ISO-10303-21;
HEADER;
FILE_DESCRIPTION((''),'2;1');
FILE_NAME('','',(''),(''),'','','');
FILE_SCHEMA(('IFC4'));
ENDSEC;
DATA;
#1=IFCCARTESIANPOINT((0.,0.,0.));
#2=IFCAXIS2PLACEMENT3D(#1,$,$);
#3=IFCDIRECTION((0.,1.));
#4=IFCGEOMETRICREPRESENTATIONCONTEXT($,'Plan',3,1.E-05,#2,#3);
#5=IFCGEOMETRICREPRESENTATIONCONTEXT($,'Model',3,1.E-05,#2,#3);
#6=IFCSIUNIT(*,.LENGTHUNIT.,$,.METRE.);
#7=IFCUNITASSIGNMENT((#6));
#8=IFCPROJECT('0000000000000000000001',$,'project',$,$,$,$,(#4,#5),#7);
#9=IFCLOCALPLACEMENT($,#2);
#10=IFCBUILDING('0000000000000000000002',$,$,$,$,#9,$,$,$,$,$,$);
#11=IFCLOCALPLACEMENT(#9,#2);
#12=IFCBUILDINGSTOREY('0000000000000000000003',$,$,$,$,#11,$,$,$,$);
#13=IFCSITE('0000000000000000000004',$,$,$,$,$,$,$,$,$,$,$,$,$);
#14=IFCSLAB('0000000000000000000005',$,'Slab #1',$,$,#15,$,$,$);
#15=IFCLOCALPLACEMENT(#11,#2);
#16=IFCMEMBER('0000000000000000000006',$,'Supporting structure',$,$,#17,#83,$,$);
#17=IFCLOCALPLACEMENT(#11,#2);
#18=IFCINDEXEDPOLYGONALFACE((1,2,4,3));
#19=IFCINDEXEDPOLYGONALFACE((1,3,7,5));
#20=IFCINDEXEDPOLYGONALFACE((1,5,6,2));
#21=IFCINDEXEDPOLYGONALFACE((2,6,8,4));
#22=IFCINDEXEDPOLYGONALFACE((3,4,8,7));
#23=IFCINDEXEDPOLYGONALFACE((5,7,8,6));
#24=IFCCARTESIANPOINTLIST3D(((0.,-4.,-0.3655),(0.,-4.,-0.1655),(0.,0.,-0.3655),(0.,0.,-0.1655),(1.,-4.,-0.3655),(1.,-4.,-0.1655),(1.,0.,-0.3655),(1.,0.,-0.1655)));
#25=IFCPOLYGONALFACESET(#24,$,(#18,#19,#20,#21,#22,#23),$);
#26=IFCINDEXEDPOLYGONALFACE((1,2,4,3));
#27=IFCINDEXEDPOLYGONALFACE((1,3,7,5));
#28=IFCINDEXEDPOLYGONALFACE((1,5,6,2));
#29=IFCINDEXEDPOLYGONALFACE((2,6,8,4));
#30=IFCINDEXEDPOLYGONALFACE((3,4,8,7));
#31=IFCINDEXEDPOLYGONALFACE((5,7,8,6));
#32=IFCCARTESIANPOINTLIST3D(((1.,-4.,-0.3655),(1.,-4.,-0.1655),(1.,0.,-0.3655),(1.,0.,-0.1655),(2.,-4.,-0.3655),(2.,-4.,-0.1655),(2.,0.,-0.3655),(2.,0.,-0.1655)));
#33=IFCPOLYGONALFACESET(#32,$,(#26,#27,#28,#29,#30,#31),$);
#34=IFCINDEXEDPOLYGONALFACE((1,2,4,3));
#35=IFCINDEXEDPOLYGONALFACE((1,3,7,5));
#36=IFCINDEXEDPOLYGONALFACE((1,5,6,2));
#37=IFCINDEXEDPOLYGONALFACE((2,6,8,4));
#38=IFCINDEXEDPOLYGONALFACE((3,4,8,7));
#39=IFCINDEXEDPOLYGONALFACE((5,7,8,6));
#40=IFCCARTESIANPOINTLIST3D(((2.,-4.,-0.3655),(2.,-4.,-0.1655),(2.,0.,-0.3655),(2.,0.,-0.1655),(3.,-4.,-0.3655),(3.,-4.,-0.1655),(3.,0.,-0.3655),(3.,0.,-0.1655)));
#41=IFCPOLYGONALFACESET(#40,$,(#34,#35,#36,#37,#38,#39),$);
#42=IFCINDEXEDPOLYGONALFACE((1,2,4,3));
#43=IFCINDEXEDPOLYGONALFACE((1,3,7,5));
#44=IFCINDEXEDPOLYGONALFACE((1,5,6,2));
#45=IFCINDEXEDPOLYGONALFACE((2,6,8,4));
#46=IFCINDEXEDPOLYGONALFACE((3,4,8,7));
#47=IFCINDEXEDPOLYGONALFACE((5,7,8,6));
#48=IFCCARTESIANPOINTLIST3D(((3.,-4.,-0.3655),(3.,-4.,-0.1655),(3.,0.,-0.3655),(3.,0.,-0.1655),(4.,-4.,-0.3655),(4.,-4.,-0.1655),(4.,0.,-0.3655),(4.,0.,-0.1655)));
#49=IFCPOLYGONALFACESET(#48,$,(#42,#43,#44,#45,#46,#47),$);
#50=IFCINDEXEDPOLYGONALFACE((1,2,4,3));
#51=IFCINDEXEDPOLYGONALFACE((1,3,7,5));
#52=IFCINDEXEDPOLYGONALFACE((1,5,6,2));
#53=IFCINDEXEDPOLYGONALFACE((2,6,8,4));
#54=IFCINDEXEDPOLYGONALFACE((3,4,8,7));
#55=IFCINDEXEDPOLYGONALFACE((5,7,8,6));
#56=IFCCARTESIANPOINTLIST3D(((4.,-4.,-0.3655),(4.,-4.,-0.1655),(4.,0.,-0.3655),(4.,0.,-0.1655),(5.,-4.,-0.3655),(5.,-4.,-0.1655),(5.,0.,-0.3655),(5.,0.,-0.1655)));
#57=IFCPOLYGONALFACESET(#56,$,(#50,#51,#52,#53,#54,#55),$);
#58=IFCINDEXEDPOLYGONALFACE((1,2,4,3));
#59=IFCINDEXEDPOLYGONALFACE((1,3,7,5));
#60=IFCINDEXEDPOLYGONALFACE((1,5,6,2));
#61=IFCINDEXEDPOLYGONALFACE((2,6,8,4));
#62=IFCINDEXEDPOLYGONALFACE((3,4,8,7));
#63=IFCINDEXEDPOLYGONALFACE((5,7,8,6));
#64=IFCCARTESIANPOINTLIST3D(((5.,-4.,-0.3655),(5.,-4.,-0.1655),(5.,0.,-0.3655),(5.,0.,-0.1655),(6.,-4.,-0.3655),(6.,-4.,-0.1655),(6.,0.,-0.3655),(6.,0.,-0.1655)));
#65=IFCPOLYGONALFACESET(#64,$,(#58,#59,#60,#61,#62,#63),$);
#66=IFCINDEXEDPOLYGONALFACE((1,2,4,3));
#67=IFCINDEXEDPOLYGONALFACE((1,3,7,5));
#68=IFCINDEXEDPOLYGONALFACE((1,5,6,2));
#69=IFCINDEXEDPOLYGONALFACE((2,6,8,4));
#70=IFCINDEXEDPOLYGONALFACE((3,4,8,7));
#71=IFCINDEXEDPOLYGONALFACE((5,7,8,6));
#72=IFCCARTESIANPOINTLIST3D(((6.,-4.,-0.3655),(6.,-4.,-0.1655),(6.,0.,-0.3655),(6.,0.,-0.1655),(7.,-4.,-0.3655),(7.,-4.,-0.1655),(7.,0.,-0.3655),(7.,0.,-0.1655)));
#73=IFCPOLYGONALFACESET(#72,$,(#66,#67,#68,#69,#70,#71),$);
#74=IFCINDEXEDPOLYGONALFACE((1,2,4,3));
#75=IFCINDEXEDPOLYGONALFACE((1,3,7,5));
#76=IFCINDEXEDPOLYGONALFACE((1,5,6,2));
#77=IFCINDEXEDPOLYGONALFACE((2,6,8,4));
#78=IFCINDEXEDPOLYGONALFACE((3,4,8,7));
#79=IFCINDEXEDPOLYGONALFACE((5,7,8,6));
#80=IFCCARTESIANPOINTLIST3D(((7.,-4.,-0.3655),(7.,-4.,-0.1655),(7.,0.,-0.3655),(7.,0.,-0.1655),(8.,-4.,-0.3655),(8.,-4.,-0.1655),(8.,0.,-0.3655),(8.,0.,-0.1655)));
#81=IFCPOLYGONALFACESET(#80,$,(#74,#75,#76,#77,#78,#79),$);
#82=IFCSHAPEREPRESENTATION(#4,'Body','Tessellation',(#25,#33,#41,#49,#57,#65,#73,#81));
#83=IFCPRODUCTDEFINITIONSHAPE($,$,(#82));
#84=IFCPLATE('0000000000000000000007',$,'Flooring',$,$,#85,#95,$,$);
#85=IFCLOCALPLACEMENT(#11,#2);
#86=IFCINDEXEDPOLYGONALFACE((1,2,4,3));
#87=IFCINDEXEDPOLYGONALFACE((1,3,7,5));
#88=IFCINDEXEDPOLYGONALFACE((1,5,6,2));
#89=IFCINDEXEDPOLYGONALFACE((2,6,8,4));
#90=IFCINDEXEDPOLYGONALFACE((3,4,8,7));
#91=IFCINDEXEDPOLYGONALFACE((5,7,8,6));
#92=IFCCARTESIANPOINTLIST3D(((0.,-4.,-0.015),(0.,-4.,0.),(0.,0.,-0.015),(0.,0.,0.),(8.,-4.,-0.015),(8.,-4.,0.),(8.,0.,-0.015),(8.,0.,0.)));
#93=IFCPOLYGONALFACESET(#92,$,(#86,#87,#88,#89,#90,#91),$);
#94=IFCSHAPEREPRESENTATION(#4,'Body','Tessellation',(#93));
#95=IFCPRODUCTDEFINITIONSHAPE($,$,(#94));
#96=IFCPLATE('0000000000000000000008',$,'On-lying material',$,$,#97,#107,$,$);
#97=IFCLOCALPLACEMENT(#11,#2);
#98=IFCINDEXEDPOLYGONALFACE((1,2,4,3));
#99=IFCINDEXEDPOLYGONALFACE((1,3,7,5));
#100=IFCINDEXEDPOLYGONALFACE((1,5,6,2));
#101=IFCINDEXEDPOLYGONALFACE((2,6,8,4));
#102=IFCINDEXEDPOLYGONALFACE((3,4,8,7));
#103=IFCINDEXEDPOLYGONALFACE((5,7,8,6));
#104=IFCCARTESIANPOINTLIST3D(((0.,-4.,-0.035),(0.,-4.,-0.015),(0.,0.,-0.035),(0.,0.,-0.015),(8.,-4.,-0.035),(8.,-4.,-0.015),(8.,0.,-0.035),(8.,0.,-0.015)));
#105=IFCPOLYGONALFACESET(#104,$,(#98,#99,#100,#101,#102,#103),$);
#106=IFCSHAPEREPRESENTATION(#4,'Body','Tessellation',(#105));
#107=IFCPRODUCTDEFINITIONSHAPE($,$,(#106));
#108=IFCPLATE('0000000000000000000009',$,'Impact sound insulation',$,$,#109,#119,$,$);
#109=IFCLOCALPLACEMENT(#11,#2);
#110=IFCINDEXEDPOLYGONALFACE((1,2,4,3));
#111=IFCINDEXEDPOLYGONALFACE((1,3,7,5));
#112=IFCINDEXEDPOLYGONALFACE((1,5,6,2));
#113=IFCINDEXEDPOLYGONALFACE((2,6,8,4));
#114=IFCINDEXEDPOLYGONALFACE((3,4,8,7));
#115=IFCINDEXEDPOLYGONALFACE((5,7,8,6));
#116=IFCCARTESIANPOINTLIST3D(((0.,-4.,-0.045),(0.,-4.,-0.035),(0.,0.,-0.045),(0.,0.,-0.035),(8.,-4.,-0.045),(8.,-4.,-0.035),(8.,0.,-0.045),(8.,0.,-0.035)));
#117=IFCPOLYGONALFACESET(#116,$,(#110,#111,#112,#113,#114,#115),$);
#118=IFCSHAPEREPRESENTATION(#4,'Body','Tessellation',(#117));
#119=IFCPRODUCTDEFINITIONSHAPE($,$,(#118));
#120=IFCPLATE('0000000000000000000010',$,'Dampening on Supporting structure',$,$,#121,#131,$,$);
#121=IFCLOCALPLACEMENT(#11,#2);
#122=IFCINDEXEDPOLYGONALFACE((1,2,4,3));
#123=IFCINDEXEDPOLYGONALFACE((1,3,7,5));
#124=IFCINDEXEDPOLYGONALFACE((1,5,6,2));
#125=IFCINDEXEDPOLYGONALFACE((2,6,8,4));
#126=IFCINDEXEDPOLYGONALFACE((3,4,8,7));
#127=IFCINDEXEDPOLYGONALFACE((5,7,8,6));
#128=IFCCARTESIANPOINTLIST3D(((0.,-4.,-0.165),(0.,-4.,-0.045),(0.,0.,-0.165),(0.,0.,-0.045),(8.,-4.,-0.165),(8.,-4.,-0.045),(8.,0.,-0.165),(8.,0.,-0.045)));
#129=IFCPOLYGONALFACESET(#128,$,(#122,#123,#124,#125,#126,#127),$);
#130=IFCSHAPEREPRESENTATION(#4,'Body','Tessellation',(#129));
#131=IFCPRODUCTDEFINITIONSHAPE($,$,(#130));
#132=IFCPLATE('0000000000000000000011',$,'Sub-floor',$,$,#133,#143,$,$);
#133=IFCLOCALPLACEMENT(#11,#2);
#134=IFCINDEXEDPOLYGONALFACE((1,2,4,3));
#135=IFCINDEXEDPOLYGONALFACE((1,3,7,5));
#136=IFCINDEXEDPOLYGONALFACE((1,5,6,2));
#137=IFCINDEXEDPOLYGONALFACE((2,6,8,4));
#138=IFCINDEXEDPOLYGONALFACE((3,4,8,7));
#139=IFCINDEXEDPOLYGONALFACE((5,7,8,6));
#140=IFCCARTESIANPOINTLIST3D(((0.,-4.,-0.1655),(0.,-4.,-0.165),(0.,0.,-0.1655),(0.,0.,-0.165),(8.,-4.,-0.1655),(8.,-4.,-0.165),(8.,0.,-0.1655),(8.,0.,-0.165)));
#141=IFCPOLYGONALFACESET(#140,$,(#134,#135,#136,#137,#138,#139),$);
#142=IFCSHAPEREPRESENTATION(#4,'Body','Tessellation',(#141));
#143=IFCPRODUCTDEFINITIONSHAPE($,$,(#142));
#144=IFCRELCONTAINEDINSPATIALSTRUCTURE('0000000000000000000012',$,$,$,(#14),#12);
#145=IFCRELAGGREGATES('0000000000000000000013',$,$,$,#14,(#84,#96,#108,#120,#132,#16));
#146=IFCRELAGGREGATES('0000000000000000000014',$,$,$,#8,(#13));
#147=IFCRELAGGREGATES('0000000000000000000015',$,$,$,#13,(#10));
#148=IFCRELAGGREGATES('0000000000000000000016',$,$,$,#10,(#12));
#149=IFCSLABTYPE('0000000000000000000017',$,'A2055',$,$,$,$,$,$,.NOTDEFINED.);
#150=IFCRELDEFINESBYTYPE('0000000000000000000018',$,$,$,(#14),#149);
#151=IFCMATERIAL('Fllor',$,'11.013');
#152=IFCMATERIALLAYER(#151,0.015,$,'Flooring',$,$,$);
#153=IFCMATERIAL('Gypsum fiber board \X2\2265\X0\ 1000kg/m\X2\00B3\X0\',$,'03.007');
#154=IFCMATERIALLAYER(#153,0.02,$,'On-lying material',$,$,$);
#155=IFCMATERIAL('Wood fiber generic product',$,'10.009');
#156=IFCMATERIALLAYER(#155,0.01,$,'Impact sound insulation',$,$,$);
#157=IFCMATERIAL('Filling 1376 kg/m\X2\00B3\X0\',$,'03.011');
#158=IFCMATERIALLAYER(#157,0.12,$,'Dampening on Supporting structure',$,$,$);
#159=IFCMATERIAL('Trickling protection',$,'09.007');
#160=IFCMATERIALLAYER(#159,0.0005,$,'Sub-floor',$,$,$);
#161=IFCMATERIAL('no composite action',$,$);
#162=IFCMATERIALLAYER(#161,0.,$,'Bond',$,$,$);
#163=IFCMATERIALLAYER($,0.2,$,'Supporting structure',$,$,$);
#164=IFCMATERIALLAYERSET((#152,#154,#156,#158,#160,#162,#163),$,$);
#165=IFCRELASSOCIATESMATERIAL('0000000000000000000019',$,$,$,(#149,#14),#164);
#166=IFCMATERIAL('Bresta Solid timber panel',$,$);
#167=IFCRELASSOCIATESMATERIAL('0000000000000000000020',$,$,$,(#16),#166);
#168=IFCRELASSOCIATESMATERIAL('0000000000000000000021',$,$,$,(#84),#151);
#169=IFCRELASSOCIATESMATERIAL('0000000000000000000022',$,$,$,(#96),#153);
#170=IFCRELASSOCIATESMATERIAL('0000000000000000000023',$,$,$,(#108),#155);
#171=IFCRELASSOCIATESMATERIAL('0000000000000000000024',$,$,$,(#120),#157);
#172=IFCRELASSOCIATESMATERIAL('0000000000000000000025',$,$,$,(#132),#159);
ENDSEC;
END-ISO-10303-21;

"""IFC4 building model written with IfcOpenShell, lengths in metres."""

from ifc_helpers import new_model, si_unit, direction, frame, frame_2d, origin, origin_with_axes, place, context, project, spatial, rectangle, extrude, material, layer, layer_set, type_object, element, aggregate, save


model = new_model("IFC4")

# Units and contexts
plan_context = context("Plan", 3, precision=1e-05, world=origin(), true_north=direction((0.0, 1.0)))
model_context = context("Model", 3, precision=1e-05, world=origin(), true_north=direction((0.0, 1.0)))
ifc_project = project(units=[si_unit("LENGTHUNIT", "METRE")], contexts=[plan_context, model_context])

# Site, building, storey
site = spatial("IfcSite", under=ifc_project)
building_placement = place(None, origin())
building = spatial("IfcBuilding", under=site, at=building_placement)
storey_placement = place(building_placement, origin())
storey = spatial("IfcBuildingStorey", under=building, at=storey_placement)

# Slab, member, plates
ifc_material_1 = material(Name="Fllor", Category="11.013")
ifc_layer_1 = layer(ifc_material_1, 0.015, Name="Flooring")
ifc_material_2 = material(Name="Gypsum fiber board ≥ 1000kg/m³", Category="03.007")
ifc_layer_2 = layer(ifc_material_2, 0.02, Name="On-lying material")
ifc_material_3 = material(Name="Wood fiber generic product", Category="10.009")
ifc_layer_3 = layer(ifc_material_3, 0.01, Name="Impact sound insulation")
ifc_material_4 = material(Name="Filling 1376 kg/m³", Category="03.011")
ifc_layer_4 = layer(ifc_material_4, 0.12, Name="Dampening on Supporting structure")
ifc_material_5 = material(Name="Trickling protection", Category="09.007")
ifc_layer_5 = layer(ifc_material_5, 0.0005, Name="Sub-floor")
ifc_material_6 = material(Name="no composite action")
ifc_layer_6 = layer(ifc_material_6, 0.0, Name="Bond")
ifc_layer_7 = layer(None, 0.2, Name="Supporting structure")
ifc_layer_set = layer_set([ifc_layer_1, ifc_layer_2, ifc_layer_3, ifc_layer_4, ifc_layer_5, ifc_layer_6, ifc_layer_7])
slab_type = type_object("IfcSlabType", Name="A2055", PredefinedType="NOTDEFINED", material=ifc_layer_set)
slab_placement = place(None, frame((0.0, 0.0, 0.0), z_axis=(0.0, 0.0, -1.0), x_axis=(1.0, 0.0, 0.0)))
slab = element("IfcSlab", 1, at=slab_placement, inside=storey, type_object=slab_type, material=ifc_layer_set, Name="Slab #1")
ifc_material_7 = material(Name="Bresta Solid timber panel")
member_placement = place(slab_placement, origin())
member = element("IfcMember", 2, at=member_placement, material=ifc_material_7, Name="Supporting structure", context=plan_context, shape_type="SweptSolid", body=[
    extrude(rectangle(XDim=1.0, YDim=0.2, at=frame_2d((0.5, 0.1), x_axis=(1.0, 0.0))), frame((0.0, 4.0, 0.1655), z_axis=(0.0, -1.0, 0.0), x_axis=(1.0, 0.0, 0.0)), (0.0, 0.0, 1.0), 4.0),
    extrude(rectangle(XDim=1.0, YDim=0.2, at=frame_2d((0.5, 0.1), x_axis=(1.0, 0.0))), frame((1.0, 4.0, 0.1655), z_axis=(0.0, -1.0, 0.0), x_axis=(1.0, 0.0, 0.0)), (0.0, 0.0, 1.0), 4.0),
    extrude(rectangle(XDim=1.0, YDim=0.2, at=frame_2d((0.5, 0.1), x_axis=(1.0, 0.0))), frame((2.0, 4.0, 0.1655), z_axis=(0.0, -1.0, 0.0), x_axis=(1.0, 0.0, 0.0)), (0.0, 0.0, 1.0), 4.0),
    extrude(rectangle(XDim=1.0, YDim=0.2, at=frame_2d((0.5, 0.1), x_axis=(1.0, 0.0))), frame((3.0, 4.0, 0.1655), z_axis=(0.0, -1.0, 0.0), x_axis=(1.0, 0.0, 0.0)), (0.0, 0.0, 1.0), 4.0),
    extrude(rectangle(XDim=1.0, YDim=0.2, at=frame_2d((0.5, 0.1), x_axis=(1.0, 0.0))), frame((4.0, 4.0, 0.1655), z_axis=(0.0, -1.0, 0.0), x_axis=(1.0, 0.0, 0.0)), (0.0, 0.0, 1.0), 4.0),
    extrude(rectangle(XDim=1.0, YDim=0.2, at=frame_2d((0.5, 0.1), x_axis=(1.0, 0.0))), frame((5.0, 4.0, 0.1655), z_axis=(0.0, -1.0, 0.0), x_axis=(1.0, 0.0, 0.0)), (0.0, 0.0, 1.0), 4.0),
    extrude(rectangle(XDim=1.0, YDim=0.2, at=frame_2d((0.5, 0.1), x_axis=(1.0, 0.0))), frame((6.0, 4.0, 0.1655), z_axis=(0.0, -1.0, 0.0), x_axis=(1.0, 0.0, 0.0)), (0.0, 0.0, 1.0), 4.0),
    extrude(rectangle(XDim=1.0, YDim=0.2, at=frame_2d((0.5, 0.1), x_axis=(1.0, 0.0))), frame((7.0, 4.0, 0.1655), z_axis=(0.0, -1.0, 0.0), x_axis=(1.0, 0.0, 0.0)), (0.0, 0.0, 1.0), 4.0),
])
plate_1_placement = place(slab_placement, origin())
plate_1 = element("IfcPlate", 3, at=plate_1_placement, material=ifc_material_1, Name="Flooring", context=plan_context, shape_type="SweptSolid", body=[
    extrude(rectangle(XDim=8.0, YDim=4.0, at=frame_2d((4.0, 2.0), x_axis=(1.0, 0.0))), origin_with_axes(), (0.0, 0.0, 1.0), 0.015),
])
plate_2_placement = place(slab_placement, origin())
plate_2 = element("IfcPlate", 4, at=plate_2_placement, material=ifc_material_2, Name="On-lying material", context=plan_context, shape_type="SweptSolid", body=[
    extrude(rectangle(XDim=8.0, YDim=4.0, at=frame_2d((4.0, 2.0), x_axis=(1.0, 0.0))), frame((0.0, 0.0, 0.015), z_axis=(0.0, 0.0, 1.0), x_axis=(1.0, 0.0, 0.0)), (0.0, 0.0, 1.0), 0.02),
])
plate_3_placement = place(slab_placement, origin())
plate_3 = element("IfcPlate", 5, at=plate_3_placement, material=ifc_material_3, Name="Impact sound insulation", context=plan_context, shape_type="SweptSolid", body=[
    extrude(rectangle(XDim=8.0, YDim=4.0, at=frame_2d((4.0, 2.0), x_axis=(1.0, 0.0))), frame((0.0, 0.0, 0.035), z_axis=(0.0, 0.0, 1.0), x_axis=(1.0, 0.0, 0.0)), (0.0, 0.0, 1.0), 0.01),
])
plate_4_placement = place(slab_placement, origin())
plate_4 = element("IfcPlate", 6, at=plate_4_placement, material=ifc_material_4, Name="Dampening on Supporting structure", context=plan_context, shape_type="SweptSolid", body=[
    extrude(rectangle(XDim=8.0, YDim=4.0, at=frame_2d((4.0, 2.0), x_axis=(1.0, 0.0))), frame((0.0, 0.0, 0.045), z_axis=(0.0, 0.0, 1.0), x_axis=(1.0, 0.0, 0.0)), (0.0, 0.0, 1.0), 0.12),
])
plate_5_placement = place(slab_placement, origin())
plate_5 = element("IfcPlate", 7, at=plate_5_placement, material=ifc_material_5, Name="Sub-floor", context=plan_context, shape_type="SweptSolid", body=[
    extrude(rectangle(XDim=8.0, YDim=4.0, at=frame_2d((4.0, 2.0), x_axis=(1.0, 0.0))), frame((0.0, 0.0, 0.165), z_axis=(0.0, 0.0, 1.0), x_axis=(1.0, 0.0, 0.0)), (0.0, 0.0, 1.0), 0.0005),
])
aggregate(slab, [plate_1, plate_2, plate_3, plate_4, plate_5, member])

save(model, "model.ifc")
